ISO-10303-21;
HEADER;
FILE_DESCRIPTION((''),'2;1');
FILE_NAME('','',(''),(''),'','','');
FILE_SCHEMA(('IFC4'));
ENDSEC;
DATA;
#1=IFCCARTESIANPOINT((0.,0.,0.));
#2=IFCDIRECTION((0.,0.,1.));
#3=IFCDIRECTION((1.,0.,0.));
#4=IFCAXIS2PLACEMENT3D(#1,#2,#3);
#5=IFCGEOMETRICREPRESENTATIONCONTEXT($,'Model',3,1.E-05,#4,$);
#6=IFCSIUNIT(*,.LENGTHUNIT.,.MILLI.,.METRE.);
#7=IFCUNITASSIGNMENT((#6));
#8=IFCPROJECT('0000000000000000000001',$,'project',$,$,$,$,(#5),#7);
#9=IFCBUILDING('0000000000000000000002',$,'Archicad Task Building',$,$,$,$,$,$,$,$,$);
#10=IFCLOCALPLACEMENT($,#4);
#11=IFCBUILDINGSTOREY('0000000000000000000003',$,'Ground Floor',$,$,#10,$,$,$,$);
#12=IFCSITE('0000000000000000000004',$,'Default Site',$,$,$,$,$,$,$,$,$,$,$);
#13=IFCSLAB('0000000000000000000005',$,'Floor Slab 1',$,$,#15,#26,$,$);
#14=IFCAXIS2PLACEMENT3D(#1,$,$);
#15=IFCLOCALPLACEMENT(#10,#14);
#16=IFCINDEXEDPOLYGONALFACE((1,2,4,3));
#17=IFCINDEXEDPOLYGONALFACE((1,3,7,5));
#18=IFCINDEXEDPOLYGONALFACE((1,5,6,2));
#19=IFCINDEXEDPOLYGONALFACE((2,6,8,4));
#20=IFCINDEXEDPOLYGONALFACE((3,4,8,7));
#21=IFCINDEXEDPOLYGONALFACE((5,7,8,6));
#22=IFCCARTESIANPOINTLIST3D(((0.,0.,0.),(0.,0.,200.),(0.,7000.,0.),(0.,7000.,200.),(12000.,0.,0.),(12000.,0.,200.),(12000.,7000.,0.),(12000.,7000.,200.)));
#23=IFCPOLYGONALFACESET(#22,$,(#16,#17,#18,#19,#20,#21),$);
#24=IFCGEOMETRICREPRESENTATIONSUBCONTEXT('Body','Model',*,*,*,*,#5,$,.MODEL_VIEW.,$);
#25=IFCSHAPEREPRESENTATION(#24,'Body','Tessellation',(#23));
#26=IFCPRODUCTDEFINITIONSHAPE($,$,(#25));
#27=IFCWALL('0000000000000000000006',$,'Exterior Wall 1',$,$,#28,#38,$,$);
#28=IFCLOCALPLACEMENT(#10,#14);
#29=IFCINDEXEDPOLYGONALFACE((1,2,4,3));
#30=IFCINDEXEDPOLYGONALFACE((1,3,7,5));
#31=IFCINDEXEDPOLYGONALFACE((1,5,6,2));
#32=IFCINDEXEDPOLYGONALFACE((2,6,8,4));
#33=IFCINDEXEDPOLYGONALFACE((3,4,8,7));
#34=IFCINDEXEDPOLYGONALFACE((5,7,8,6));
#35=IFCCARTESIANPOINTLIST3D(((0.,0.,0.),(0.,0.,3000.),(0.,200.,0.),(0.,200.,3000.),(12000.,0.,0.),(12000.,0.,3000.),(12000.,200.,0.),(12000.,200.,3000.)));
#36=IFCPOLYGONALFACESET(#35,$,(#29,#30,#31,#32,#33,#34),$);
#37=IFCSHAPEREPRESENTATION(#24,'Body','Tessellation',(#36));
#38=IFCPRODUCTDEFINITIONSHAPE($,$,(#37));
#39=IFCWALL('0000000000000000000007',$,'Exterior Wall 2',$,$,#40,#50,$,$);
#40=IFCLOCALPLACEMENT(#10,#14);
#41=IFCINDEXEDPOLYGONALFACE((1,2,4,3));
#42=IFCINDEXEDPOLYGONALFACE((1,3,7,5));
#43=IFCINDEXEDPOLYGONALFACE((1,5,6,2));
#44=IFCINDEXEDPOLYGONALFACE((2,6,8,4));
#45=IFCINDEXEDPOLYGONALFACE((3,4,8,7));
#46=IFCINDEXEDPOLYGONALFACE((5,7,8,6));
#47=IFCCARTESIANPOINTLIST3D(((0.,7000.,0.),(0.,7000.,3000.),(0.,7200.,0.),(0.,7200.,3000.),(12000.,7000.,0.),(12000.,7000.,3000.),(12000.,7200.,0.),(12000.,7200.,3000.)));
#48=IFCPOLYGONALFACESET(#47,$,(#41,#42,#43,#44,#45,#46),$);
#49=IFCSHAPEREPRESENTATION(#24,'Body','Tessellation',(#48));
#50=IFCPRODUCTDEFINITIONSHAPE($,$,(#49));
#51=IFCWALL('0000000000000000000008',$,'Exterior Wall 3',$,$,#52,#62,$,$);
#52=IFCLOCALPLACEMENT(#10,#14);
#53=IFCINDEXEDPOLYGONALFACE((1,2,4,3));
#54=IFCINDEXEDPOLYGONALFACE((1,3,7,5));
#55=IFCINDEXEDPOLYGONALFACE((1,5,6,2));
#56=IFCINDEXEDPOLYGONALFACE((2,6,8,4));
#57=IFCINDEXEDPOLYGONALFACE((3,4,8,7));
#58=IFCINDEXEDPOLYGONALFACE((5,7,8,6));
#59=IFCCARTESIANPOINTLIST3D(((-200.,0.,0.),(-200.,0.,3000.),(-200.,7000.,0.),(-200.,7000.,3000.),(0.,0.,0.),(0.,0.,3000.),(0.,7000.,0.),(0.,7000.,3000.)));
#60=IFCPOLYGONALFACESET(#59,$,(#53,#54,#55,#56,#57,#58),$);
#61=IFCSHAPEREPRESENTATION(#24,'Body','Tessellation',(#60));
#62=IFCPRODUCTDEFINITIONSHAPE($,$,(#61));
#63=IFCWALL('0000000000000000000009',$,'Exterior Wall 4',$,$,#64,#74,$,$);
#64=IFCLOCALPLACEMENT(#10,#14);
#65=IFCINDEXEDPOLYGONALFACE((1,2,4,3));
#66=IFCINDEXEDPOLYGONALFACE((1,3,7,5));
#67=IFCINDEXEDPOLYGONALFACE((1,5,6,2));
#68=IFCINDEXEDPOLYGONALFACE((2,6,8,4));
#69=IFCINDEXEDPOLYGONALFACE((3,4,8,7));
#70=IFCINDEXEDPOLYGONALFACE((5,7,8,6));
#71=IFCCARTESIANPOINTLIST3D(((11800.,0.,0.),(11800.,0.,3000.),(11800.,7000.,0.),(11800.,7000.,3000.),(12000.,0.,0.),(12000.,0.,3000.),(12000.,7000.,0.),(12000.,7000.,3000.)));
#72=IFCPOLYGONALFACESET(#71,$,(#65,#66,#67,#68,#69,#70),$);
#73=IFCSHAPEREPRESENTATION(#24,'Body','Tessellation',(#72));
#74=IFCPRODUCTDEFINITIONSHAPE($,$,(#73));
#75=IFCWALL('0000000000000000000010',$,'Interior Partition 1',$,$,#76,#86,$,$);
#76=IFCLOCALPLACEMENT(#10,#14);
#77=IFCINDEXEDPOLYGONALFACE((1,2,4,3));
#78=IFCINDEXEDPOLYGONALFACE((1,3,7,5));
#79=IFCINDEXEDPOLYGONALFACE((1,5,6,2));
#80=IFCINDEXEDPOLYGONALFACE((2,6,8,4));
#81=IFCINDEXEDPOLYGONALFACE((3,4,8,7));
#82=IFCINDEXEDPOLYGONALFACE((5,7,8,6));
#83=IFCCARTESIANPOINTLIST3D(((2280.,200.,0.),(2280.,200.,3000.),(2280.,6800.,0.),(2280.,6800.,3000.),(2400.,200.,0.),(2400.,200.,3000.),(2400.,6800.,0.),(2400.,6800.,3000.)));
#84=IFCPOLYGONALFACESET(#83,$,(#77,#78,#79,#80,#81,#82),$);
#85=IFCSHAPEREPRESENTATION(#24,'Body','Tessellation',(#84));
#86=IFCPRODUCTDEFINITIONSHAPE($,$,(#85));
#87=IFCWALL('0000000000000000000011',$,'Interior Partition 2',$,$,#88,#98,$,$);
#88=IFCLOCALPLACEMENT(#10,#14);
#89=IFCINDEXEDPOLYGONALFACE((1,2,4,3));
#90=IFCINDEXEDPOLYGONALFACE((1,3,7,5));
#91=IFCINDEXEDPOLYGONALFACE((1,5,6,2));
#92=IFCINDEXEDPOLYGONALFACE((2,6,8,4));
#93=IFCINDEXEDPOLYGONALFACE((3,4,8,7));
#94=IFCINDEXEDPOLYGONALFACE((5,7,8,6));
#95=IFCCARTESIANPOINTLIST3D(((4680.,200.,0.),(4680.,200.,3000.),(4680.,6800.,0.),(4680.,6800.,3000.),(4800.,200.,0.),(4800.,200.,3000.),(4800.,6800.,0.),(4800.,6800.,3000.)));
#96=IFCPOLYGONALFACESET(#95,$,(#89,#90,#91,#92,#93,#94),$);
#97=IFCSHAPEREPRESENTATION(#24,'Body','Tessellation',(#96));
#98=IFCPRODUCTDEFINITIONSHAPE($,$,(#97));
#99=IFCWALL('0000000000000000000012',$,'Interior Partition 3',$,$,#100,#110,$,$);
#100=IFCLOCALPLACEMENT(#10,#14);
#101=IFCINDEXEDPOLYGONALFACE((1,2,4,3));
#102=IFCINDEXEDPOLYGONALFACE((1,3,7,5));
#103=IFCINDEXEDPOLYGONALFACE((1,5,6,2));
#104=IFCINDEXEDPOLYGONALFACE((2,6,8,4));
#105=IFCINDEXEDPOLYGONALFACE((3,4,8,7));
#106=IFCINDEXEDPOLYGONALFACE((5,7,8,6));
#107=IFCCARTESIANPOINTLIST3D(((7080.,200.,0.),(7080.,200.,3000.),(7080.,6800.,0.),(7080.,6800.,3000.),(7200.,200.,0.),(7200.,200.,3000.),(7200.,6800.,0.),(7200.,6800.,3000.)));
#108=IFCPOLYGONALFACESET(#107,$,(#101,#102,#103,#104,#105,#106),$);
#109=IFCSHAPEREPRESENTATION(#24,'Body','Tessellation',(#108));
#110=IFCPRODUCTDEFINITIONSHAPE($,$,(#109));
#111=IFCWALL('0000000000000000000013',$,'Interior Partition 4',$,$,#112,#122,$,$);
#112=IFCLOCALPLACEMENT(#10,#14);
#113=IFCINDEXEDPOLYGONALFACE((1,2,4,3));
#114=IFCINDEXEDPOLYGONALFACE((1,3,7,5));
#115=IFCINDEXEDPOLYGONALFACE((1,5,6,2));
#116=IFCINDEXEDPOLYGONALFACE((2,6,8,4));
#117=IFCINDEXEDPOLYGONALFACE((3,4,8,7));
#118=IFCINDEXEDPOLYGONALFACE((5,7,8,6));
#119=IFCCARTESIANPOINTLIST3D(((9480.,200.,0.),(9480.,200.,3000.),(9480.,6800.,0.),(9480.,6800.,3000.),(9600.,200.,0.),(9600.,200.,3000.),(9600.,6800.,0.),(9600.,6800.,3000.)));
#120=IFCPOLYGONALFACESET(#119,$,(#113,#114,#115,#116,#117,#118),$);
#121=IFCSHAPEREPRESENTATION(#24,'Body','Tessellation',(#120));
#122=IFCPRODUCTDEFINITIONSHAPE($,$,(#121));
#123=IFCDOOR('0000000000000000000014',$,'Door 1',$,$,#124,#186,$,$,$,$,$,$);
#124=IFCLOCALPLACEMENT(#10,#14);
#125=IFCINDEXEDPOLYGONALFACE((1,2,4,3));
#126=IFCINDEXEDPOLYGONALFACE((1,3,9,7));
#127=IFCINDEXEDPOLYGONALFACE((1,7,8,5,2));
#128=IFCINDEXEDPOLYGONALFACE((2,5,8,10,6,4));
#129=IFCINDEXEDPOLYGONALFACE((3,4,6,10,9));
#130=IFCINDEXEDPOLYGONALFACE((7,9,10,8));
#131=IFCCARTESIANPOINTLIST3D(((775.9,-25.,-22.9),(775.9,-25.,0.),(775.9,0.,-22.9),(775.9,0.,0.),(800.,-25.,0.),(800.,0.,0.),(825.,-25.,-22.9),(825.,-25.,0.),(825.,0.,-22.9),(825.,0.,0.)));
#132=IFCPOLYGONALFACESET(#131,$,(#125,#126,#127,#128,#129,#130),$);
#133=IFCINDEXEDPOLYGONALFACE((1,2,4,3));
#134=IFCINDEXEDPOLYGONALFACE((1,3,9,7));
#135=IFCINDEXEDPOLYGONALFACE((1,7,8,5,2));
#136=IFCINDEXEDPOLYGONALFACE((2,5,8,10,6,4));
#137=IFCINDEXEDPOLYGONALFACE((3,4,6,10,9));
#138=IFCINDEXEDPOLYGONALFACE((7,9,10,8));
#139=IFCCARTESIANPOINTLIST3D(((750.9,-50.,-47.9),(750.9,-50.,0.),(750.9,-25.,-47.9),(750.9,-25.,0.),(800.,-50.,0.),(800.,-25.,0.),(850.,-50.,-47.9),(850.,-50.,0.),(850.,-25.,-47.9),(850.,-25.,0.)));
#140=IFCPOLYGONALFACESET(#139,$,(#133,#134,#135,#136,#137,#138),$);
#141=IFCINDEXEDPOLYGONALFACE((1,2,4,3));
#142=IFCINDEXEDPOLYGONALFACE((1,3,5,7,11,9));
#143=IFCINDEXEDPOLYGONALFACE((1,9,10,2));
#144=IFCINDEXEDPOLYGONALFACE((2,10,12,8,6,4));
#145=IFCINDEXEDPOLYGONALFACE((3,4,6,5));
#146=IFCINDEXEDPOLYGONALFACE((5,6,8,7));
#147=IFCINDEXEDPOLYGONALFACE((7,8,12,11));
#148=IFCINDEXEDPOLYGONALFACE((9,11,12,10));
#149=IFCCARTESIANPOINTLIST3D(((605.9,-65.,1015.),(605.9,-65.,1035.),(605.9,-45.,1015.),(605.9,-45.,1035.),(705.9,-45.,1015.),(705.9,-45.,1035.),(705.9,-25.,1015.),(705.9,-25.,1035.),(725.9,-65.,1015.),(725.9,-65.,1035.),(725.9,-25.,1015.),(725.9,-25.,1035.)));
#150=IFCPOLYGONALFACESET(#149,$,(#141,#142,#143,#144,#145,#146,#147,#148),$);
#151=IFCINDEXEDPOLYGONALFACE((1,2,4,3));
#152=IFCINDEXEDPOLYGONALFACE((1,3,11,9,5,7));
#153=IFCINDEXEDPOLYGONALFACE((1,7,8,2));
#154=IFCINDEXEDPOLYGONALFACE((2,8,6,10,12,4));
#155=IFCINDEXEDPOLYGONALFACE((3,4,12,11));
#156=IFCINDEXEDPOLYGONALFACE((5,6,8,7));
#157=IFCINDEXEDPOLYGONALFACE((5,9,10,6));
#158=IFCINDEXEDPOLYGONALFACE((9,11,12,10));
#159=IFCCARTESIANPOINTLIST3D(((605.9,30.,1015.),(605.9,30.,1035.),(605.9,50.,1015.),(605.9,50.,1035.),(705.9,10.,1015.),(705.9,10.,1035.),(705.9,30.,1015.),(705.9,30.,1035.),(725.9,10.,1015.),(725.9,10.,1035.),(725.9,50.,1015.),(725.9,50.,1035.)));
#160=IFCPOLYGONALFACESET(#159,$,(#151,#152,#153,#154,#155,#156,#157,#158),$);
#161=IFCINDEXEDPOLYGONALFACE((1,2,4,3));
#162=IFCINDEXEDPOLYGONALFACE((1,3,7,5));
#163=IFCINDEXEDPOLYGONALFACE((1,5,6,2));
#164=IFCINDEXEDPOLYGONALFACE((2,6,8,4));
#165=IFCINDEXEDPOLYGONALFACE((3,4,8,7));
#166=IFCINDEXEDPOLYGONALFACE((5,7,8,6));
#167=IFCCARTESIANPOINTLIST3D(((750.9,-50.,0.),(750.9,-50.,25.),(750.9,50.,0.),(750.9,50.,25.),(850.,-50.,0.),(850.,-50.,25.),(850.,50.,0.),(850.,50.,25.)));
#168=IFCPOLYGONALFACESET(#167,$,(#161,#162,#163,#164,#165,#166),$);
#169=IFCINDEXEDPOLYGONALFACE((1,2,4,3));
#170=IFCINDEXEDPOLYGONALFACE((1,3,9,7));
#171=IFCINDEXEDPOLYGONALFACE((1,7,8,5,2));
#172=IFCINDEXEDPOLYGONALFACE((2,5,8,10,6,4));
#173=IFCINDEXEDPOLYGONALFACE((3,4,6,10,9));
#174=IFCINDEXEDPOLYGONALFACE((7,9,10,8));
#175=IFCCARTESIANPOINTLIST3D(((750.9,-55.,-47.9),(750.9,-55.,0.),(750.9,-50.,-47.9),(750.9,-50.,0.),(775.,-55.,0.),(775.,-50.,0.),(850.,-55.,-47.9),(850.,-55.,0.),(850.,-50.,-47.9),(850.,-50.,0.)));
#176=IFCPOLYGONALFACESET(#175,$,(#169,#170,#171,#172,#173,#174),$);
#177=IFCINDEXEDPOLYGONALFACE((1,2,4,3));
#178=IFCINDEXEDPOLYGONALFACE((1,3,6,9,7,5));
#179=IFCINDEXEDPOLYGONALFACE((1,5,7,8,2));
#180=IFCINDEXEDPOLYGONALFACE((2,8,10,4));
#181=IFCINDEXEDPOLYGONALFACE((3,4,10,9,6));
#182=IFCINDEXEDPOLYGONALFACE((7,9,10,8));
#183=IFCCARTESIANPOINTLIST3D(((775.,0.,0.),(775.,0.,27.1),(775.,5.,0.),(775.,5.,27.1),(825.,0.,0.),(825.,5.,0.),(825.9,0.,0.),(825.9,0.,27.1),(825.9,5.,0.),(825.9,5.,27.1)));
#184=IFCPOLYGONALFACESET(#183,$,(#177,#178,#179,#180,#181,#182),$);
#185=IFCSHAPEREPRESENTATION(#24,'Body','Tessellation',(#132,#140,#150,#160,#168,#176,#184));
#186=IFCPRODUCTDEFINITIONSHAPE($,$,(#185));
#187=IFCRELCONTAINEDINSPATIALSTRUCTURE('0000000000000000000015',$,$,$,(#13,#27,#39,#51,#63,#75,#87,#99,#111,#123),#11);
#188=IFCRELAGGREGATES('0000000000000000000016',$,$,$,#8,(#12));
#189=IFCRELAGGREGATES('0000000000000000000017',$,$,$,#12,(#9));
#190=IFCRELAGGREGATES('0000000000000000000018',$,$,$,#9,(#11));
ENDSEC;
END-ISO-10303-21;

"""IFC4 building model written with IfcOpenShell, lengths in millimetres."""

from ifc_helpers import new_model, si_unit, frame, origin_with_axes, place, context, subcontext, project, spatial, line, indexed_curve, outline, extrude, element, save


model = new_model("IFC4")

# Units and contexts
model_context = context("Model", 3, precision=1e-05, world=origin_with_axes())
body_context = subcontext(model_context, "Body", "Model", "MODEL_VIEW")
ifc_project = project(units=[si_unit("LENGTHUNIT", "METRE", prefix="MILLI")], contexts=[model_context])

# Site, building, storey
site = spatial("IfcSite", under=ifc_project, Name="Default Site")
building = spatial("IfcBuilding", under=site, Name="Archicad Task Building")
storey_placement = place(None, origin_with_axes())
storey = spatial("IfcBuildingStorey", under=building, at=storey_placement, Name="Ground Floor")

# Slab
slab_placement = place(storey_placement, origin_with_axes())
element("IfcSlab", 1, at=slab_placement, inside=storey, Name="Floor Slab 1", context=body_context, shape_type="SweptSolid", body=[
    extrude(outline(indexed_curve([(0.0, 0.0), (12000.0, 0.0), (12000.0, 7000.0), (0.0, 7000.0), (0.0, 0.0)])), None, (0.0, 0.0, 1.0), 200.0),
])

# Walls
for number, where, z_axis, x_axis, name in (
    (2, (0.0, 0.0, 0.0), (0.0, 0.0, 1.0), (1.0, 0.0, 0.0), "Exterior Wall 1"),
    (3, (0.0, 7000.0, 0.0), (0.0, 0.0, 1.0), (1.0, 0.0, 0.0), "Exterior Wall 2"),
):
    element("IfcWall", number, at=place(storey_placement, frame(where, z_axis=z_axis, x_axis=x_axis)), inside=storey, Name=name, context=body_context, shape_type="SweptSolid", body=[
        extrude(outline(indexed_curve([(0.0, 0.0), (0.0, 200.0), (12000.0, 200.0), (12000.0, 0.0), (0.0, 0.0)], self_intersect=False)), origin_with_axes(), (0.0, 0.0, 1.0), 3000.0),
    ])
for number, where, z_axis, x_axis, name in (
    (4, (0.0, 0.0, 0.0), (0.0, 0.0, 1.0), (0.0, 1.0, 0.0), "Exterior Wall 3"),
    (5, (12000.0, 0.0, 0.0), (0.0, 0.0, 1.0), (0.0, 1.0, 0.0), "Exterior Wall 4"),
):
    element("IfcWall", number, at=place(storey_placement, frame(where, z_axis=z_axis, x_axis=x_axis)), inside=storey, Name=name, context=body_context, shape_type="SweptSolid", body=[
        extrude(outline(indexed_curve([(0.0, 0.0), (0.0, 200.0), (7000.0, 200.0), (7000.0, 0.0), (0.0, 0.0)], self_intersect=False)), origin_with_axes(), (0.0, 0.0, 1.0), 3000.0),
    ])
for number, where, z_axis, x_axis, name in (
    (6, (2400.0, 200.0, 0.0), (0.0, 0.0, 1.0), (0.0, 1.0, 0.0), "Interior Partition 1"),
    (7, (4800.0, 200.0, 0.0), (0.0, 0.0, 1.0), (0.0, 1.0, 0.0), "Interior Partition 2"),
    (8, (7200.0, 200.0, 0.0), (0.0, 0.0, 1.0), (0.0, 1.0, 0.0), "Interior Partition 3"),
    (9, (9600.0, 200.0, 0.0), (0.0, 0.0, 1.0), (0.0, 1.0, 0.0), "Interior Partition 4"),
):
    element("IfcWall", number, at=place(storey_placement, frame(where, z_axis=z_axis, x_axis=x_axis)), inside=storey, Name=name, context=body_context, shape_type="SweptSolid", body=[
        extrude(outline(indexed_curve([(0.0, 0.0), (0.0, 120.0), (6600.0, 120.0), (6600.0, 0.0), (0.0, 0.0)], self_intersect=False)), origin_with_axes(), (0.0, 0.0, 1.0), 3000.0),
    ])

# Door
door_1_placement = place(storey_placement, frame((800.0, -50.0, 0.0), z_axis=(0.0, 0.0, 1.0), x_axis=(1.0, 0.0, 0.0)))
element("IfcDoor", 10, at=door_1_placement, inside=storey, Name="Door 1", context=body_context, shape_type="SweptSolid", body=[
    extrude(outline(indexed_curve([(0.0, 0.0), (0.0, 2.1), (0.9, 2.1), (0.9, 0.0), (-24.1, 0.0), (-24.1, -22.9), (25.0, -22.9), (25.0, 0.0)], segments=[line(1, 2, 3, 4, 5, 6, 7, 8, 1)])), frame((0.0, 25.0, 0.0), z_axis=(0.0, -1.0, 0.0), x_axis=(1.0, 0.0, 0.0)), (0.0, 0.0, -1.0), 25.0),
    extrude(outline(indexed_curve([(0.0, 0.0), (0.0, 2.1), (0.9, 2.1), (0.9, 0.0), (-49.1, 0.0), (-49.1, -47.9), (50.0, -47.9), (50.0, 0.0)], segments=[line(1, 2, 3, 4, 5, 6, 7, 8, 1)])), frame((0.0, 0.0, 0.0), z_axis=(0.0, -1.0, 0.0), x_axis=(1.0, 0.0, 0.0)), (0.0, 0.0, -1.0), 25.0),
    extrude(outline(indexed_curve([(0.0, 0.0), (-49.1, 0.0), (-49.1, 35.0), (0.0, 35.0)], segments=[line(1, 2, 3, 4, 1)])), frame((25.0, 25.0, 25.0), z_axis=(0.0, 0.0, 1.0), x_axis=(1.0, 0.0, 0.0)), (0.0, 0.0, 1.0), -47.9),
    extrude(outline(indexed_curve([(0.0, 0.0), (0.0, -40.0), (-120.0, -40.0), (-120.0, -20.0), (-20.0, -20.0), (-20.0, 0.0)], segments=[line(1, 2, 3, 4, 5, 6, 1)])), frame((-74.1, 25.0, 1015.0), z_axis=(0.0, 0.0, 1.0), x_axis=(1.0, 0.0, 0.0)), (0.0, 0.0, 1.0), 20.0),
    extrude(outline(indexed_curve([(0.0, 0.0), (0.0, 40.0), (-120.0, 40.0), (-120.0, 20.0), (-20.0, 20.0), (-20.0, 0.0)], segments=[line(1, 2, 3, 4, 5, 6, 1)])), frame((-74.1, 60.0, 1015.0), z_axis=(0.0, 0.0, 1.0), x_axis=(1.0, 0.0, 0.0)), (0.0, 0.0, 1.0), 20.0),
    extrude(outline(indexed_curve([(0.0, 0.0), (-99.1, 0.0), (-99.1, 100.0), (0.0, 100.0)], segments=[line(1, 2, 3, 4, 1)])), frame((50.0, 0.0, 0.0), z_axis=(0.0, 0.0, 1.0), x_axis=(1.0, 0.0, 0.0)), (0.0, 0.0, 1.0), 25.0),
    extrude(outline(indexed_curve([(0.0, 0.0), (0.0, 27.1), (50.9, 27.1), (50.9, 0.0), (-24.1, 0.0), (-24.1, -47.9), (75.0, -47.9), (75.0, 0.0)], segments=[line(1, 2, 3, 4, 5, 6, 7, 8, 1)])), frame((-25.0, -5.0, 0.0), z_axis=(0.0, -1.0, 0.0), x_axis=(1.0, 0.0, 0.0)), (0.0, 0.0, -1.0), 5.0),
    extrude(outline(indexed_curve([(0.0, 0.0), (0.0, 27.1), (50.9, 27.1), (50.9, 0.0), (0.9, 0.0), (0.9, -22.9), (50.0, -22.9), (50.0, 0.0)], segments=[line(1, 2, 3, 4, 5, 6, 7, 8, 1)])), frame((-25.0, 50.0, 0.0), z_axis=(0.0, -1.0, 0.0), x_axis=(1.0, 0.0, 0.0)), (0.0, 0.0, -1.0), 5.0),
])

save(model, "model.ifc")
